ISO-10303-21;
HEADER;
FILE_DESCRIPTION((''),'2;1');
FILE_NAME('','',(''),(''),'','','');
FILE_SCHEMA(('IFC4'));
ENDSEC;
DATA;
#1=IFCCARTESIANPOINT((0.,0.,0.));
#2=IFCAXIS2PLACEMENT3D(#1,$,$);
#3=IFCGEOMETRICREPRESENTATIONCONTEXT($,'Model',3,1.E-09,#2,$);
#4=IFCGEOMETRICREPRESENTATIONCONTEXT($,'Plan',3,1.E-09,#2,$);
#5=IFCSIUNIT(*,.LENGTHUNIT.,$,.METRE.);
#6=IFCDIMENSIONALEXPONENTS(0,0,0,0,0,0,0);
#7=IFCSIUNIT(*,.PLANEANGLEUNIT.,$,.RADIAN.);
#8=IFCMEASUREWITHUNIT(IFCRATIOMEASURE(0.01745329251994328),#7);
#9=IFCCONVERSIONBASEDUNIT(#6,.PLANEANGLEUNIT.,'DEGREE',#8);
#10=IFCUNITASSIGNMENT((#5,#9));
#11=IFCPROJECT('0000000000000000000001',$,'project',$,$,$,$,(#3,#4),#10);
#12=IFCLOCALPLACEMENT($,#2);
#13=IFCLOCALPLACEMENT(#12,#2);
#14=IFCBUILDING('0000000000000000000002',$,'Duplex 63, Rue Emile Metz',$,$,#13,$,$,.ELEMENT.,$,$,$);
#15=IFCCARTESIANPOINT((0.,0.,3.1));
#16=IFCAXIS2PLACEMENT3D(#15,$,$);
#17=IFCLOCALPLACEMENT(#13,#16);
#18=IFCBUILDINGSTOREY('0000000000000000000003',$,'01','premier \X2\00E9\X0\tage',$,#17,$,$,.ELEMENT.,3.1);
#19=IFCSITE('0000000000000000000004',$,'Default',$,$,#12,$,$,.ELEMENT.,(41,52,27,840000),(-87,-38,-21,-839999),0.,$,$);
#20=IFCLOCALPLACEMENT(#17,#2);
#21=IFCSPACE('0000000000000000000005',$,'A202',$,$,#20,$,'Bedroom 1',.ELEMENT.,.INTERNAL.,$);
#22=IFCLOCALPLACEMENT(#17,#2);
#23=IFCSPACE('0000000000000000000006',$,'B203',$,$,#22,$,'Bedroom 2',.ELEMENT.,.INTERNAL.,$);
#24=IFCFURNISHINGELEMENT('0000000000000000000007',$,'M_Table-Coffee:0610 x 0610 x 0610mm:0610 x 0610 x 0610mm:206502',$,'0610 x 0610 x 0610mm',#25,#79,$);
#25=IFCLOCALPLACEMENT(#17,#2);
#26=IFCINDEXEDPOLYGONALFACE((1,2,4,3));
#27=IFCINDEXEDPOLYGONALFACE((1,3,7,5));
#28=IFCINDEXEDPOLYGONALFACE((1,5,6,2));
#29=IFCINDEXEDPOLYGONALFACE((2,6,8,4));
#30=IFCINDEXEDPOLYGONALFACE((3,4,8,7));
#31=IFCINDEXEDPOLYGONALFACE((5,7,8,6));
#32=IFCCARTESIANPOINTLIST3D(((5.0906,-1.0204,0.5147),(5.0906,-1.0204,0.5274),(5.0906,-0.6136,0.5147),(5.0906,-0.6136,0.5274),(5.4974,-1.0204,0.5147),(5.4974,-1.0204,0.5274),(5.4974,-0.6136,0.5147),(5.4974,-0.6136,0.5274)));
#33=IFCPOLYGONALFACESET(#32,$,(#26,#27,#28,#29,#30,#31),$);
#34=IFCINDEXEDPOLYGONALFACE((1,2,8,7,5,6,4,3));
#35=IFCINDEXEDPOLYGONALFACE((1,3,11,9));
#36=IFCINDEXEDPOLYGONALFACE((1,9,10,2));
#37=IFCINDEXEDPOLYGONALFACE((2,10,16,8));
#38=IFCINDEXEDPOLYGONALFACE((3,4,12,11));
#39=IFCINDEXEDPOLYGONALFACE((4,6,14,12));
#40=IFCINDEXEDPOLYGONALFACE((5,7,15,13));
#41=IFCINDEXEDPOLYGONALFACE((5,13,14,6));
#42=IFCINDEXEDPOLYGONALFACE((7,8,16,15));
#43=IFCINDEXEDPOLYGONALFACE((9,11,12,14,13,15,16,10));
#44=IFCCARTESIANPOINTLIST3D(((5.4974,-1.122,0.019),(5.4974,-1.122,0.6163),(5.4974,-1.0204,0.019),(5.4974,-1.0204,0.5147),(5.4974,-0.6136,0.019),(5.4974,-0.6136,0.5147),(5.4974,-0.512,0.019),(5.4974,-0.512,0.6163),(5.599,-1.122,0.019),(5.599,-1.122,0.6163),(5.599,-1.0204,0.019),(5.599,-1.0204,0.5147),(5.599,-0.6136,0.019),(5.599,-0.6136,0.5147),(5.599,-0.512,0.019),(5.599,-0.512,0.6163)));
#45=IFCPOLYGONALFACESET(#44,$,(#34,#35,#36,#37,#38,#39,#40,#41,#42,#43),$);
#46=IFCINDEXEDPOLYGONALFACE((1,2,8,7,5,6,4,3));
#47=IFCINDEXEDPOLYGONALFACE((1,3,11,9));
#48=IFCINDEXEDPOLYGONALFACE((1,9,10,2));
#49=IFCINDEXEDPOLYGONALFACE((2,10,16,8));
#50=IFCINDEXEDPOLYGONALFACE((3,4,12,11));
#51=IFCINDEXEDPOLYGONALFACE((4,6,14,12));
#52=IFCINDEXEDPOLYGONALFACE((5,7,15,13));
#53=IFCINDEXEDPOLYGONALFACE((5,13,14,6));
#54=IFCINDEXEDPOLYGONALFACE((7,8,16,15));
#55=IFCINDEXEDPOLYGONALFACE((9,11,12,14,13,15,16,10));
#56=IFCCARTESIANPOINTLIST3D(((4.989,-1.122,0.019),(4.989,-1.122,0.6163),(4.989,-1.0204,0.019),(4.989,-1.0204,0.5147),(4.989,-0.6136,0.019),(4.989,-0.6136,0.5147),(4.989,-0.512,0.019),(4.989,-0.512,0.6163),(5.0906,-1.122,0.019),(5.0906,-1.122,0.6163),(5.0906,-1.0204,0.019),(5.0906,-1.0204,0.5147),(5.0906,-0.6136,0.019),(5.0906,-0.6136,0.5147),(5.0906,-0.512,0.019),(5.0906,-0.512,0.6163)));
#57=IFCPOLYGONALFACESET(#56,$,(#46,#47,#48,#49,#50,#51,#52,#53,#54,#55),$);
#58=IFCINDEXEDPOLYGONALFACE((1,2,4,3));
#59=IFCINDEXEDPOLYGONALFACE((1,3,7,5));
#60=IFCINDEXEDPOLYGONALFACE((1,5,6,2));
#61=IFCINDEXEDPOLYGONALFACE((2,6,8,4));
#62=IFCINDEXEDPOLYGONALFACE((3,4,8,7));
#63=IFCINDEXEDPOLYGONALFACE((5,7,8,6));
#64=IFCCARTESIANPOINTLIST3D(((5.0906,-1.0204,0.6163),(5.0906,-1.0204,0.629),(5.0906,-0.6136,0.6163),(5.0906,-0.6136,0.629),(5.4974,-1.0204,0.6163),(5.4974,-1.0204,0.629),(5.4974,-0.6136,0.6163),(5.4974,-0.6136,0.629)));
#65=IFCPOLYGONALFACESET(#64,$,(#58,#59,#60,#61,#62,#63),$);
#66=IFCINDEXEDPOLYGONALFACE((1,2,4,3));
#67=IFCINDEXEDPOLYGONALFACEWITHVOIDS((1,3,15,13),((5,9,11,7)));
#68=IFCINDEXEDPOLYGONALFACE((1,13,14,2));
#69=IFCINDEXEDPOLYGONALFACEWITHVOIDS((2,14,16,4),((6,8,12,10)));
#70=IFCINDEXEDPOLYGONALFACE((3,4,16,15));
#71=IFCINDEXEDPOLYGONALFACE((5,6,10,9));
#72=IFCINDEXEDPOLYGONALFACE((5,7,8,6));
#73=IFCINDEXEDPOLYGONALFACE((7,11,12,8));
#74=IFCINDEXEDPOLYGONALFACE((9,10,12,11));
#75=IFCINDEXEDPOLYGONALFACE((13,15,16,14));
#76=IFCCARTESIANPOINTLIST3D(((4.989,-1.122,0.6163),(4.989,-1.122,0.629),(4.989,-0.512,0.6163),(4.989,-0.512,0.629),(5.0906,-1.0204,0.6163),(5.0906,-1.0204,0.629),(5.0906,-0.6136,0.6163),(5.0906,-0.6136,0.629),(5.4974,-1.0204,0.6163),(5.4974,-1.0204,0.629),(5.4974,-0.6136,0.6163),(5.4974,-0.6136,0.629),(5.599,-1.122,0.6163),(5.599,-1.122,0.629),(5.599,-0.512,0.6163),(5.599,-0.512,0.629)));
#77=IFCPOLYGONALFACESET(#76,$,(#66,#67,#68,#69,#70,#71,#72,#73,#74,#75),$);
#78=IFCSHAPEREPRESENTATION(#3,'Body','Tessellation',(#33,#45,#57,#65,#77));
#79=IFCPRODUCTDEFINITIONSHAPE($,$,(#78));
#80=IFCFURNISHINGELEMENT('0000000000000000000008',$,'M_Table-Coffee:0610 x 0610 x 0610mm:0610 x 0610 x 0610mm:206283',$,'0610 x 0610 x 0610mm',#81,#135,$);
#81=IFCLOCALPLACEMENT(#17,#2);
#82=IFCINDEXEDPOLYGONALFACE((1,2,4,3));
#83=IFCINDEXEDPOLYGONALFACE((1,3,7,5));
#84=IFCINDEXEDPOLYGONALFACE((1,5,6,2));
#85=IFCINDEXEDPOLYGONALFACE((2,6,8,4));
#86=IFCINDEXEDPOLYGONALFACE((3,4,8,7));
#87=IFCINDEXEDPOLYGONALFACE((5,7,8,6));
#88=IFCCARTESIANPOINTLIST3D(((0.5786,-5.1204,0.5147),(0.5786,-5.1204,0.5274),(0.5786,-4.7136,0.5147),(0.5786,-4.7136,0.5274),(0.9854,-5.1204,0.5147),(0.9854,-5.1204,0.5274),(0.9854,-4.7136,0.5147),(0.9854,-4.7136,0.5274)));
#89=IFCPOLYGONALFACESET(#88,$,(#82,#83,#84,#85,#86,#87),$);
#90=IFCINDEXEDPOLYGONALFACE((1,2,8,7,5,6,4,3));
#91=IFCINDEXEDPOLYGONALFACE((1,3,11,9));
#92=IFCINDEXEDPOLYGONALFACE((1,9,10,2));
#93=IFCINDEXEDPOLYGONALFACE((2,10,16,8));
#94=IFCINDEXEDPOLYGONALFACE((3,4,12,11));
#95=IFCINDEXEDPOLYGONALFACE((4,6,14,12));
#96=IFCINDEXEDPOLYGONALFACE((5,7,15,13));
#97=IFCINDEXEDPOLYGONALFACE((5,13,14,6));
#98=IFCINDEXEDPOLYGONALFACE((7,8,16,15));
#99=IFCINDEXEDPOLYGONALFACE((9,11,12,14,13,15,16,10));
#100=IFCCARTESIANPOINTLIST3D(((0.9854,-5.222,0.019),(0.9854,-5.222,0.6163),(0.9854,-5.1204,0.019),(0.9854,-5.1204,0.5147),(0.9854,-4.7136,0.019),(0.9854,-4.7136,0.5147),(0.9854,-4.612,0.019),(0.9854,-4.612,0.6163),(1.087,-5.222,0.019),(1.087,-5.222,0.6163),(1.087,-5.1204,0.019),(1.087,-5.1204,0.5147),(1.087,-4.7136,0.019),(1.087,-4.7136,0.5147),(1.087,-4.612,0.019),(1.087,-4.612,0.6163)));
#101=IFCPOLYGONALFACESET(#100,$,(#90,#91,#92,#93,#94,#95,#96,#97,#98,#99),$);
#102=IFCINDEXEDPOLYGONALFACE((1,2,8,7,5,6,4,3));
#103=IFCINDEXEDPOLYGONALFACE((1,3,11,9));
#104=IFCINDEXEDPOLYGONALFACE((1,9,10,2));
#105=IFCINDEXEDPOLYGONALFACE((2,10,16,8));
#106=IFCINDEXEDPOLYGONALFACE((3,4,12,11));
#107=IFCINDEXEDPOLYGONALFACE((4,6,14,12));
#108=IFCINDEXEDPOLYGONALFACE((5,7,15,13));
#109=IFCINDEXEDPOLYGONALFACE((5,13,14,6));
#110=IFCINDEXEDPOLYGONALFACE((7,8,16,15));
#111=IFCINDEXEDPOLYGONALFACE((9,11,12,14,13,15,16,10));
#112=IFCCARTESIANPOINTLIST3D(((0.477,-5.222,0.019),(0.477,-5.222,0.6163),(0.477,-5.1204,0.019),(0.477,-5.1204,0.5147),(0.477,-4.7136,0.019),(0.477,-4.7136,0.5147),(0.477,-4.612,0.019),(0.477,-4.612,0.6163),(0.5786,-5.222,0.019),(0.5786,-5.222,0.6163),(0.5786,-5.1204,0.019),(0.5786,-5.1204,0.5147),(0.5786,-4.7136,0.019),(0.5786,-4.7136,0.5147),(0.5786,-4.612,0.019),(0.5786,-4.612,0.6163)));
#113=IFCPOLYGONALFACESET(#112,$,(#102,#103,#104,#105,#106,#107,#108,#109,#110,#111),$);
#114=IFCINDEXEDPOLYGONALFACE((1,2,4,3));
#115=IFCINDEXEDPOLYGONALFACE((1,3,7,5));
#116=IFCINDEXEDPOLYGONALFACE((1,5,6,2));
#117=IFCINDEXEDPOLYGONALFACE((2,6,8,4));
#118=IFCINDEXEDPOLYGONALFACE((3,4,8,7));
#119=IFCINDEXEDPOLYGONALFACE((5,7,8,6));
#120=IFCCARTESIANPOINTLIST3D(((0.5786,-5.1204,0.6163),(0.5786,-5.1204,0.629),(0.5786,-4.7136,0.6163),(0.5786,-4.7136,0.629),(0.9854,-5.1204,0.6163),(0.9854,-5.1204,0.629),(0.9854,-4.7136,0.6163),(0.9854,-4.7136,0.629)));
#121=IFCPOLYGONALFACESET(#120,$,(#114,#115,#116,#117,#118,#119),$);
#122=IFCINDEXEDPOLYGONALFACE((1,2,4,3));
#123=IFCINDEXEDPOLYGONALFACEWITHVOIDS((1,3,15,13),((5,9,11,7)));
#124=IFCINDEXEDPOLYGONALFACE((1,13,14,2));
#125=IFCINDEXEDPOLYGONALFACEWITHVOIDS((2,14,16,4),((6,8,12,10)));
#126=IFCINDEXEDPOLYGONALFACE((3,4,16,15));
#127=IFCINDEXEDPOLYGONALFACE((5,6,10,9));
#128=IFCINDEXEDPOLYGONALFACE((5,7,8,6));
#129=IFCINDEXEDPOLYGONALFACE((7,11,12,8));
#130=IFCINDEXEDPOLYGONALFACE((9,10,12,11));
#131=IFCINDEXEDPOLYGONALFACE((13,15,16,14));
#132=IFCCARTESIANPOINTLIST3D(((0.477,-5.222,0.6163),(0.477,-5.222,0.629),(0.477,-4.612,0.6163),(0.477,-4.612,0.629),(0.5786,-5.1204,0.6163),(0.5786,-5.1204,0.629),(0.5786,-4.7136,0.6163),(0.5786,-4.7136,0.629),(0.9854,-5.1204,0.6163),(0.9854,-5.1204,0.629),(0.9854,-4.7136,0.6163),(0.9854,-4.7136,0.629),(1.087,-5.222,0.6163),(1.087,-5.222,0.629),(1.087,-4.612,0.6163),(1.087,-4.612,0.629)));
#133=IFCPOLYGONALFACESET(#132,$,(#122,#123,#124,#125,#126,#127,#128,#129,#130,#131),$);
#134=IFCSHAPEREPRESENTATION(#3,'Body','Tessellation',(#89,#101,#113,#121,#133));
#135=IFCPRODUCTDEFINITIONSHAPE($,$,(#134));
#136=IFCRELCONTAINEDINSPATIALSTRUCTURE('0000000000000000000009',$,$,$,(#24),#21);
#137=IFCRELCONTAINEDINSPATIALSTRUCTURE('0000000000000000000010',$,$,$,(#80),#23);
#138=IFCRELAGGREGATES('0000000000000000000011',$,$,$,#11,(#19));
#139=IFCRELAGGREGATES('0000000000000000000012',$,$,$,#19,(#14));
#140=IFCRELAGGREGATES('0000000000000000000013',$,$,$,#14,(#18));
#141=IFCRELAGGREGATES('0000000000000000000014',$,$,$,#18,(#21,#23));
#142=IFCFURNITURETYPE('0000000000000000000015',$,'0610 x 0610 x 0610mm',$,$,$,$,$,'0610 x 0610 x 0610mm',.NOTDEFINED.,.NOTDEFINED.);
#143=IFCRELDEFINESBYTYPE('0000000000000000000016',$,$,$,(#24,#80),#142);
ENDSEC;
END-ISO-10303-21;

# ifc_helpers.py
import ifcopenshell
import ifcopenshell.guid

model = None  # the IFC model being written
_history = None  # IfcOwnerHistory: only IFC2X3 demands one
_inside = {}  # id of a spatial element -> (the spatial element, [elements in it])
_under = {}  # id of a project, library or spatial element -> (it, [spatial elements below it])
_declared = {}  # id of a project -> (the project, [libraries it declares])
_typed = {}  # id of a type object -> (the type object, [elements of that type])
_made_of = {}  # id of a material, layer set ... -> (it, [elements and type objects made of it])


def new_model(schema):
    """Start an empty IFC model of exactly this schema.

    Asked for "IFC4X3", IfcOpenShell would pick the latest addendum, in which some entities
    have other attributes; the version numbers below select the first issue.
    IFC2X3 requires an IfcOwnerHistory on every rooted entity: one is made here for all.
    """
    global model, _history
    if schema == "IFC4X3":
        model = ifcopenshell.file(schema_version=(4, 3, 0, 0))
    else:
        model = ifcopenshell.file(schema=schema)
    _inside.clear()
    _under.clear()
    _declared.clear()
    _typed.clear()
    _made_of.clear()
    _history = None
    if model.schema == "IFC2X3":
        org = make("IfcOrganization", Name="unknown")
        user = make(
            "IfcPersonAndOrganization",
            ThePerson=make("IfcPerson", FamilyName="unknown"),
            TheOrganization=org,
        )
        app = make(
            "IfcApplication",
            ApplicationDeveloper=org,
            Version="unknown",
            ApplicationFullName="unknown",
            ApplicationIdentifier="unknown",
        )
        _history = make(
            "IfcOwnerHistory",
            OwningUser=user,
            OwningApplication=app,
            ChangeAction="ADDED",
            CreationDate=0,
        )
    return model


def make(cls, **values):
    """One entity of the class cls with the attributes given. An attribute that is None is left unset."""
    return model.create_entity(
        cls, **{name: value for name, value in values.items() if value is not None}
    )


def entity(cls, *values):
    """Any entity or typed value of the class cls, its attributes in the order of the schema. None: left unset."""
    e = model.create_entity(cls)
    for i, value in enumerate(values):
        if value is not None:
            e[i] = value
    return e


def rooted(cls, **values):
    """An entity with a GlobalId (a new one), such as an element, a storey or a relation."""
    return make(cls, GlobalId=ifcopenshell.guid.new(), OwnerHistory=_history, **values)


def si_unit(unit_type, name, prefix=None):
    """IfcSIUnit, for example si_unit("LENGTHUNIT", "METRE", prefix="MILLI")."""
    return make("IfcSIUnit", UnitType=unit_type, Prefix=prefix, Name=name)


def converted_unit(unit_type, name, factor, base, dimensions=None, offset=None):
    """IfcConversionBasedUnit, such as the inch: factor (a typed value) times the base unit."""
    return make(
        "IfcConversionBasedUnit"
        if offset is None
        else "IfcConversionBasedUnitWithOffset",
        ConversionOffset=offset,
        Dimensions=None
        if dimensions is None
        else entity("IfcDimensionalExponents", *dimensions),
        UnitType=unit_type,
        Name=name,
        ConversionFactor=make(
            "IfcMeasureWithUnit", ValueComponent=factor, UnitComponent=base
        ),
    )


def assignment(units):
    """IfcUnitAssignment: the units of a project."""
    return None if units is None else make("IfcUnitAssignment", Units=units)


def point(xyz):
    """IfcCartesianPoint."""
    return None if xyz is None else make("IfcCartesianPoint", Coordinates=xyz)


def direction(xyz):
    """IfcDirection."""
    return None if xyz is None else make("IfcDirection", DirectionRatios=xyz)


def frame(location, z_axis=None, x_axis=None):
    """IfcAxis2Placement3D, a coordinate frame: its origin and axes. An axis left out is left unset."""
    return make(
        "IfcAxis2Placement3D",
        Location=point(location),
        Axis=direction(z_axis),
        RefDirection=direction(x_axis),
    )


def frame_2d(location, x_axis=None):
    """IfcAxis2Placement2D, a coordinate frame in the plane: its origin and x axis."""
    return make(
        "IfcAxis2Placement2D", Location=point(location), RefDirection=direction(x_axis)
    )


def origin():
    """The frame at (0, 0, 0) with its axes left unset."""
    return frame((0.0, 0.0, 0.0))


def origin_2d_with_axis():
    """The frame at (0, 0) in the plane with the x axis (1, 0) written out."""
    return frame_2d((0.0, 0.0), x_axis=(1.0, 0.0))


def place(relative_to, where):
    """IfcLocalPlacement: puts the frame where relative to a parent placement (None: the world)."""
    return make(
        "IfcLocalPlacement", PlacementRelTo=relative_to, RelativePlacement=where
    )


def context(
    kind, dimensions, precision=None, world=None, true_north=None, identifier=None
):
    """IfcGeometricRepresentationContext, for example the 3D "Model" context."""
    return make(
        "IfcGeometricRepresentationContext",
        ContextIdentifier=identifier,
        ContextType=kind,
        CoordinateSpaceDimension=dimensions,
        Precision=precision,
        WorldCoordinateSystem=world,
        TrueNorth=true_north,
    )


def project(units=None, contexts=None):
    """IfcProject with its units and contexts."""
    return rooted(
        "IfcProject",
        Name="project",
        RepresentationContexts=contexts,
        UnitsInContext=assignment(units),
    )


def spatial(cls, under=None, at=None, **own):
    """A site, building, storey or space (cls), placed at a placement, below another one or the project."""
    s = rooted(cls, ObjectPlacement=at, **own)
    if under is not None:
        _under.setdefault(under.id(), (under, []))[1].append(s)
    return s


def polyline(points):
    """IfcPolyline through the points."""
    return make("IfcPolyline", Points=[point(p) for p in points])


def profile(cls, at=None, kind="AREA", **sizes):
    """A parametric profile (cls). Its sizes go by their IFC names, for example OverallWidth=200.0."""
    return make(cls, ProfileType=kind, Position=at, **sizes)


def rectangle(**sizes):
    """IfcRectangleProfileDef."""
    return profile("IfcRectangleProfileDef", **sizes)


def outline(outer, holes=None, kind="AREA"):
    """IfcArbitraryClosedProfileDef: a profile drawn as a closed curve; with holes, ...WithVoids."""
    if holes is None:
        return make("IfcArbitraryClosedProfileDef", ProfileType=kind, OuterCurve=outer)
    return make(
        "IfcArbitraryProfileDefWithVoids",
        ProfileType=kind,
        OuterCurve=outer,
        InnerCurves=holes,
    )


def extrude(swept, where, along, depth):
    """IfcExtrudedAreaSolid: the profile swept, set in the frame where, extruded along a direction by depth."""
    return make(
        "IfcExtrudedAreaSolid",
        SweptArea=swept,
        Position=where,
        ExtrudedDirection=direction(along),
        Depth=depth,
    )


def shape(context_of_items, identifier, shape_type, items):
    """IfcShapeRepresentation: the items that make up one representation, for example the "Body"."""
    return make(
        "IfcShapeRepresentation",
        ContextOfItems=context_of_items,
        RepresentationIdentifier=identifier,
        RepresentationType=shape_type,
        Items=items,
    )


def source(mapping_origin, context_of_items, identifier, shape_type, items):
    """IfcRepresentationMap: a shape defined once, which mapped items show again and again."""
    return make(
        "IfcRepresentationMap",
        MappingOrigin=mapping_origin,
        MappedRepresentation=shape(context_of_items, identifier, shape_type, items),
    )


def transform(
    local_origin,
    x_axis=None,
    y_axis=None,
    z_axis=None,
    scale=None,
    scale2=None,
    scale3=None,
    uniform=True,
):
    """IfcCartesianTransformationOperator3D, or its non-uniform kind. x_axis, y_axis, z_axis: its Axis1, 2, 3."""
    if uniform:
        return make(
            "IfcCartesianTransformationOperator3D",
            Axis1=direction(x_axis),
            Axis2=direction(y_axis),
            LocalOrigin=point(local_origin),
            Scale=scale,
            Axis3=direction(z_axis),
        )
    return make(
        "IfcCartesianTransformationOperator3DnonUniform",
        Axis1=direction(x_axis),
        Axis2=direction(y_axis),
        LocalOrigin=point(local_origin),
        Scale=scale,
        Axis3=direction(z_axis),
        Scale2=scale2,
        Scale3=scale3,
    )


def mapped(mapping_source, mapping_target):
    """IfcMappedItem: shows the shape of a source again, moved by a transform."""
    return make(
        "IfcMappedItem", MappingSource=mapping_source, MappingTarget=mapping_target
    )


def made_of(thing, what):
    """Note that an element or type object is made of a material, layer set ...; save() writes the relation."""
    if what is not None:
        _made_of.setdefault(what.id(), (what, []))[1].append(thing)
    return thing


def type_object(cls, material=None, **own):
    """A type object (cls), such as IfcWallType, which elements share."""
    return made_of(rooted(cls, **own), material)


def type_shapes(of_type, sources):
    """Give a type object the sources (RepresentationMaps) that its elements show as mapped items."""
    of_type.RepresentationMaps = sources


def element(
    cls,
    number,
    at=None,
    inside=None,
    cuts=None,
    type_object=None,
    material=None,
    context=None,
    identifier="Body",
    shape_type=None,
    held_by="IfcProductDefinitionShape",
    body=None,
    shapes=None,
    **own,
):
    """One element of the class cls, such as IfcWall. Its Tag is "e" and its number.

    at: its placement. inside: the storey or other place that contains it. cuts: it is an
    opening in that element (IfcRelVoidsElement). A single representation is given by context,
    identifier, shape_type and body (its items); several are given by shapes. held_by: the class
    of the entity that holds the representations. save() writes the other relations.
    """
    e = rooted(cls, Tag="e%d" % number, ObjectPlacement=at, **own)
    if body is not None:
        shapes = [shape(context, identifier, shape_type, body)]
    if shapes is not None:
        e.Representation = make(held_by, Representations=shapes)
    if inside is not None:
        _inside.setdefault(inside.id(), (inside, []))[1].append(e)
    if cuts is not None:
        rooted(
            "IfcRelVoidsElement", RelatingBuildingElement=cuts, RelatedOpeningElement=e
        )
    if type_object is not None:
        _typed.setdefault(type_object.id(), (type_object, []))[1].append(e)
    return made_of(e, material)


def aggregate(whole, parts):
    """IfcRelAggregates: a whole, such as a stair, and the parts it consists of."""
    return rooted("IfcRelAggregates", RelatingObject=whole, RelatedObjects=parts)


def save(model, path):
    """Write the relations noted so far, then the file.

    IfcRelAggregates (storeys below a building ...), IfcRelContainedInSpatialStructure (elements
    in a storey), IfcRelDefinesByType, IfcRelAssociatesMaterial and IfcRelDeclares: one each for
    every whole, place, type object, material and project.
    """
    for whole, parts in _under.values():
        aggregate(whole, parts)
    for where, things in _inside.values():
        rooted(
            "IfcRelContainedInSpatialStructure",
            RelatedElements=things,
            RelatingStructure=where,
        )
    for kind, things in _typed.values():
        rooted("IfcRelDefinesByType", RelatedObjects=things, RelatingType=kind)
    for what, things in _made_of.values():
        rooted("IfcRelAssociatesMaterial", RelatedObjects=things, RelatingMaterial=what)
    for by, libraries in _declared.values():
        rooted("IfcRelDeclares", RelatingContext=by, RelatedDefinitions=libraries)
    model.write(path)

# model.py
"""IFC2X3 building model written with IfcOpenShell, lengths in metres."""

from ifc_helpers import new_model, entity, si_unit, converted_unit, frame, origin, origin_2d_with_axis, place, context, project, spatial, polyline, rectangle, outline, extrude, source, transform, mapped, type_object, type_shapes, element, save


model = new_model("IFC2X3")

# Units and contexts
model_context = context("Model", 3, precision=1e-09, world=origin())
plan_context = context("Plan", 3, precision=1e-09, world=origin())
ifc_project = project(units=[si_unit("LENGTHUNIT", "METRE"), converted_unit("PLANEANGLEUNIT", "DEGREE", entity("IfcRatioMeasure", 0.01745329251994328), si_unit("PLANEANGLEUNIT", "RADIAN"), dimensions=[0, 0, 0, 0, 0, 0, 0])], contexts=[model_context, plan_context])

# Site, building, storey
site_placement = place(None, origin())
site = spatial("IfcSite", under=ifc_project, at=site_placement, Name="Default", CompositionType="ELEMENT", RefLatitude=(41, 52, 27, 840000), RefLongitude=(-87, -38, -21, -839999), RefElevation=0.0)
building_placement = place(site_placement, origin())
building = spatial("IfcBuilding", under=site, at=building_placement, Name="Duplex 63, Rue Emile Metz", CompositionType="ELEMENT")
storey_placement = place(building_placement, frame((0.0, 0.0, 3.1)))
storey = spatial("IfcBuildingStorey", under=building, at=storey_placement, Name="01", Description="premier étage", CompositionType="ELEMENT", Elevation=3.1)

# Shared definitions
space_1_placement = place(storey_placement, origin())
space_1 = spatial("IfcSpace", under=storey, at=space_1_placement, Name="A202", LongName="Bedroom 1", CompositionType="ELEMENT", InteriorOrExteriorSpace="INTERNAL")

# Furnishing element
furniture_type = type_object("IfcFurnitureType", Name="0610 x 0610 x 0610mm", ElementType="0610 x 0610 x 0610mm", AssemblyPlace="NOTDEFINED")
shared_shape_1 = source(origin(), model_context, "Body", "SweptSolid", [
    extrude(rectangle(XDim=0.4068, YDim=0.4068, at=origin_2d_with_axis()), frame((0.0183, 0.0952, 0.4957), z_axis=(0.0, 0.0, 1.0), x_axis=(-1.0, 0.0, 0.0)), (0.0, 0.0, 1.0), 0.0127),
    extrude(outline(polyline([(-0.2732, -0.305), (0.324, -0.305), (0.324, 0.305), (-0.2732, 0.305), (-0.2732, 0.2034), (0.2225, 0.2034), (0.2225, -0.2034), (-0.2732, -0.2034), (-0.2732, -0.305)])), frame((0.2217, 0.0952, 0.2732), z_axis=(1.0, 0.0, 0.0), x_axis=(0.0, 0.0, 1.0)), (0.0, 0.0, 1.0), 0.1016),
    extrude(outline(polyline([(-0.305, -0.3241), (0.305, -0.3241), (0.305, 0.2733), (0.2034, 0.2733), (0.2034, -0.2224), (-0.2034, -0.2224), (-0.2034, 0.2733), (-0.305, 0.2733), (-0.305, -0.3241)])), frame((-0.2867, 0.0952, 0.2733), z_axis=(1.0, 0.0, 0.0), x_axis=(0.0, -1.0, 0.0)), (0.0, 0.0, 1.0), 0.1016),
    extrude(rectangle(XDim=0.4068, YDim=0.4068, at=origin_2d_with_axis()), frame((0.0183, 0.0952, 0.5973), z_axis=(0.0, 0.0, 1.0), x_axis=(-1.0, 0.0, 0.0)), (0.0, 0.0, 1.0), 0.0127),
    extrude(outline(polyline([(-0.305, -0.305), (0.305, -0.305), (0.305, 0.305), (-0.305, 0.305), (-0.305, -0.305)]), holes=[polyline([(-0.2034, -0.2034), (-0.2034, 0.2034), (0.2034, 0.2034), (0.2034, -0.2034), (-0.2034, -0.2034)])]), frame((0.0183, 0.0952, 0.5973), z_axis=(0.0, 0.0, 1.0), x_axis=(-1.0, 0.0, 0.0)), (0.0, 0.0, 1.0), 0.0127),
])
type_shapes(furniture_type, [shared_shape_1])
furnishing_1_placement = place(space_1_placement, frame((5.2757, -0.9122, 0.019)))
element("IfcFurnishingElement", 1, at=furnishing_1_placement, inside=space_1, type_object=furniture_type, Name="M_Table-Coffee:0610 x 0610 x 0610mm:0610 x 0610 x 0610mm:206502", ObjectType="0610 x 0610 x 0610mm", context=model_context, shape_type="MappedRepresentation", body=[
    mapped(shared_shape_1, transform((0.0, 0.0, 0.0), scale=1.0)),
])

# Shared definitions
space_2_placement = place(storey_placement, origin())
space_2 = spatial("IfcSpace", under=storey, at=space_2_placement, Name="B203", LongName="Bedroom 2", CompositionType="ELEMENT", InteriorOrExteriorSpace="INTERNAL")

# Furnishing element
furnishing_2_placement = place(space_2_placement, frame((0.7637, -5.0122, 0.019)))
element("IfcFurnishingElement", 2, at=furnishing_2_placement, inside=space_2, type_object=furniture_type, Name="M_Table-Coffee:0610 x 0610 x 0610mm:0610 x 0610 x 0610mm:206283", ObjectType="0610 x 0610 x 0610mm", context=model_context, shape_type="MappedRepresentation", body=[
    mapped(shared_shape_1, transform((0.0, 0.0, 0.0), scale=1.0)),
])

save(model, "model.ifc")
